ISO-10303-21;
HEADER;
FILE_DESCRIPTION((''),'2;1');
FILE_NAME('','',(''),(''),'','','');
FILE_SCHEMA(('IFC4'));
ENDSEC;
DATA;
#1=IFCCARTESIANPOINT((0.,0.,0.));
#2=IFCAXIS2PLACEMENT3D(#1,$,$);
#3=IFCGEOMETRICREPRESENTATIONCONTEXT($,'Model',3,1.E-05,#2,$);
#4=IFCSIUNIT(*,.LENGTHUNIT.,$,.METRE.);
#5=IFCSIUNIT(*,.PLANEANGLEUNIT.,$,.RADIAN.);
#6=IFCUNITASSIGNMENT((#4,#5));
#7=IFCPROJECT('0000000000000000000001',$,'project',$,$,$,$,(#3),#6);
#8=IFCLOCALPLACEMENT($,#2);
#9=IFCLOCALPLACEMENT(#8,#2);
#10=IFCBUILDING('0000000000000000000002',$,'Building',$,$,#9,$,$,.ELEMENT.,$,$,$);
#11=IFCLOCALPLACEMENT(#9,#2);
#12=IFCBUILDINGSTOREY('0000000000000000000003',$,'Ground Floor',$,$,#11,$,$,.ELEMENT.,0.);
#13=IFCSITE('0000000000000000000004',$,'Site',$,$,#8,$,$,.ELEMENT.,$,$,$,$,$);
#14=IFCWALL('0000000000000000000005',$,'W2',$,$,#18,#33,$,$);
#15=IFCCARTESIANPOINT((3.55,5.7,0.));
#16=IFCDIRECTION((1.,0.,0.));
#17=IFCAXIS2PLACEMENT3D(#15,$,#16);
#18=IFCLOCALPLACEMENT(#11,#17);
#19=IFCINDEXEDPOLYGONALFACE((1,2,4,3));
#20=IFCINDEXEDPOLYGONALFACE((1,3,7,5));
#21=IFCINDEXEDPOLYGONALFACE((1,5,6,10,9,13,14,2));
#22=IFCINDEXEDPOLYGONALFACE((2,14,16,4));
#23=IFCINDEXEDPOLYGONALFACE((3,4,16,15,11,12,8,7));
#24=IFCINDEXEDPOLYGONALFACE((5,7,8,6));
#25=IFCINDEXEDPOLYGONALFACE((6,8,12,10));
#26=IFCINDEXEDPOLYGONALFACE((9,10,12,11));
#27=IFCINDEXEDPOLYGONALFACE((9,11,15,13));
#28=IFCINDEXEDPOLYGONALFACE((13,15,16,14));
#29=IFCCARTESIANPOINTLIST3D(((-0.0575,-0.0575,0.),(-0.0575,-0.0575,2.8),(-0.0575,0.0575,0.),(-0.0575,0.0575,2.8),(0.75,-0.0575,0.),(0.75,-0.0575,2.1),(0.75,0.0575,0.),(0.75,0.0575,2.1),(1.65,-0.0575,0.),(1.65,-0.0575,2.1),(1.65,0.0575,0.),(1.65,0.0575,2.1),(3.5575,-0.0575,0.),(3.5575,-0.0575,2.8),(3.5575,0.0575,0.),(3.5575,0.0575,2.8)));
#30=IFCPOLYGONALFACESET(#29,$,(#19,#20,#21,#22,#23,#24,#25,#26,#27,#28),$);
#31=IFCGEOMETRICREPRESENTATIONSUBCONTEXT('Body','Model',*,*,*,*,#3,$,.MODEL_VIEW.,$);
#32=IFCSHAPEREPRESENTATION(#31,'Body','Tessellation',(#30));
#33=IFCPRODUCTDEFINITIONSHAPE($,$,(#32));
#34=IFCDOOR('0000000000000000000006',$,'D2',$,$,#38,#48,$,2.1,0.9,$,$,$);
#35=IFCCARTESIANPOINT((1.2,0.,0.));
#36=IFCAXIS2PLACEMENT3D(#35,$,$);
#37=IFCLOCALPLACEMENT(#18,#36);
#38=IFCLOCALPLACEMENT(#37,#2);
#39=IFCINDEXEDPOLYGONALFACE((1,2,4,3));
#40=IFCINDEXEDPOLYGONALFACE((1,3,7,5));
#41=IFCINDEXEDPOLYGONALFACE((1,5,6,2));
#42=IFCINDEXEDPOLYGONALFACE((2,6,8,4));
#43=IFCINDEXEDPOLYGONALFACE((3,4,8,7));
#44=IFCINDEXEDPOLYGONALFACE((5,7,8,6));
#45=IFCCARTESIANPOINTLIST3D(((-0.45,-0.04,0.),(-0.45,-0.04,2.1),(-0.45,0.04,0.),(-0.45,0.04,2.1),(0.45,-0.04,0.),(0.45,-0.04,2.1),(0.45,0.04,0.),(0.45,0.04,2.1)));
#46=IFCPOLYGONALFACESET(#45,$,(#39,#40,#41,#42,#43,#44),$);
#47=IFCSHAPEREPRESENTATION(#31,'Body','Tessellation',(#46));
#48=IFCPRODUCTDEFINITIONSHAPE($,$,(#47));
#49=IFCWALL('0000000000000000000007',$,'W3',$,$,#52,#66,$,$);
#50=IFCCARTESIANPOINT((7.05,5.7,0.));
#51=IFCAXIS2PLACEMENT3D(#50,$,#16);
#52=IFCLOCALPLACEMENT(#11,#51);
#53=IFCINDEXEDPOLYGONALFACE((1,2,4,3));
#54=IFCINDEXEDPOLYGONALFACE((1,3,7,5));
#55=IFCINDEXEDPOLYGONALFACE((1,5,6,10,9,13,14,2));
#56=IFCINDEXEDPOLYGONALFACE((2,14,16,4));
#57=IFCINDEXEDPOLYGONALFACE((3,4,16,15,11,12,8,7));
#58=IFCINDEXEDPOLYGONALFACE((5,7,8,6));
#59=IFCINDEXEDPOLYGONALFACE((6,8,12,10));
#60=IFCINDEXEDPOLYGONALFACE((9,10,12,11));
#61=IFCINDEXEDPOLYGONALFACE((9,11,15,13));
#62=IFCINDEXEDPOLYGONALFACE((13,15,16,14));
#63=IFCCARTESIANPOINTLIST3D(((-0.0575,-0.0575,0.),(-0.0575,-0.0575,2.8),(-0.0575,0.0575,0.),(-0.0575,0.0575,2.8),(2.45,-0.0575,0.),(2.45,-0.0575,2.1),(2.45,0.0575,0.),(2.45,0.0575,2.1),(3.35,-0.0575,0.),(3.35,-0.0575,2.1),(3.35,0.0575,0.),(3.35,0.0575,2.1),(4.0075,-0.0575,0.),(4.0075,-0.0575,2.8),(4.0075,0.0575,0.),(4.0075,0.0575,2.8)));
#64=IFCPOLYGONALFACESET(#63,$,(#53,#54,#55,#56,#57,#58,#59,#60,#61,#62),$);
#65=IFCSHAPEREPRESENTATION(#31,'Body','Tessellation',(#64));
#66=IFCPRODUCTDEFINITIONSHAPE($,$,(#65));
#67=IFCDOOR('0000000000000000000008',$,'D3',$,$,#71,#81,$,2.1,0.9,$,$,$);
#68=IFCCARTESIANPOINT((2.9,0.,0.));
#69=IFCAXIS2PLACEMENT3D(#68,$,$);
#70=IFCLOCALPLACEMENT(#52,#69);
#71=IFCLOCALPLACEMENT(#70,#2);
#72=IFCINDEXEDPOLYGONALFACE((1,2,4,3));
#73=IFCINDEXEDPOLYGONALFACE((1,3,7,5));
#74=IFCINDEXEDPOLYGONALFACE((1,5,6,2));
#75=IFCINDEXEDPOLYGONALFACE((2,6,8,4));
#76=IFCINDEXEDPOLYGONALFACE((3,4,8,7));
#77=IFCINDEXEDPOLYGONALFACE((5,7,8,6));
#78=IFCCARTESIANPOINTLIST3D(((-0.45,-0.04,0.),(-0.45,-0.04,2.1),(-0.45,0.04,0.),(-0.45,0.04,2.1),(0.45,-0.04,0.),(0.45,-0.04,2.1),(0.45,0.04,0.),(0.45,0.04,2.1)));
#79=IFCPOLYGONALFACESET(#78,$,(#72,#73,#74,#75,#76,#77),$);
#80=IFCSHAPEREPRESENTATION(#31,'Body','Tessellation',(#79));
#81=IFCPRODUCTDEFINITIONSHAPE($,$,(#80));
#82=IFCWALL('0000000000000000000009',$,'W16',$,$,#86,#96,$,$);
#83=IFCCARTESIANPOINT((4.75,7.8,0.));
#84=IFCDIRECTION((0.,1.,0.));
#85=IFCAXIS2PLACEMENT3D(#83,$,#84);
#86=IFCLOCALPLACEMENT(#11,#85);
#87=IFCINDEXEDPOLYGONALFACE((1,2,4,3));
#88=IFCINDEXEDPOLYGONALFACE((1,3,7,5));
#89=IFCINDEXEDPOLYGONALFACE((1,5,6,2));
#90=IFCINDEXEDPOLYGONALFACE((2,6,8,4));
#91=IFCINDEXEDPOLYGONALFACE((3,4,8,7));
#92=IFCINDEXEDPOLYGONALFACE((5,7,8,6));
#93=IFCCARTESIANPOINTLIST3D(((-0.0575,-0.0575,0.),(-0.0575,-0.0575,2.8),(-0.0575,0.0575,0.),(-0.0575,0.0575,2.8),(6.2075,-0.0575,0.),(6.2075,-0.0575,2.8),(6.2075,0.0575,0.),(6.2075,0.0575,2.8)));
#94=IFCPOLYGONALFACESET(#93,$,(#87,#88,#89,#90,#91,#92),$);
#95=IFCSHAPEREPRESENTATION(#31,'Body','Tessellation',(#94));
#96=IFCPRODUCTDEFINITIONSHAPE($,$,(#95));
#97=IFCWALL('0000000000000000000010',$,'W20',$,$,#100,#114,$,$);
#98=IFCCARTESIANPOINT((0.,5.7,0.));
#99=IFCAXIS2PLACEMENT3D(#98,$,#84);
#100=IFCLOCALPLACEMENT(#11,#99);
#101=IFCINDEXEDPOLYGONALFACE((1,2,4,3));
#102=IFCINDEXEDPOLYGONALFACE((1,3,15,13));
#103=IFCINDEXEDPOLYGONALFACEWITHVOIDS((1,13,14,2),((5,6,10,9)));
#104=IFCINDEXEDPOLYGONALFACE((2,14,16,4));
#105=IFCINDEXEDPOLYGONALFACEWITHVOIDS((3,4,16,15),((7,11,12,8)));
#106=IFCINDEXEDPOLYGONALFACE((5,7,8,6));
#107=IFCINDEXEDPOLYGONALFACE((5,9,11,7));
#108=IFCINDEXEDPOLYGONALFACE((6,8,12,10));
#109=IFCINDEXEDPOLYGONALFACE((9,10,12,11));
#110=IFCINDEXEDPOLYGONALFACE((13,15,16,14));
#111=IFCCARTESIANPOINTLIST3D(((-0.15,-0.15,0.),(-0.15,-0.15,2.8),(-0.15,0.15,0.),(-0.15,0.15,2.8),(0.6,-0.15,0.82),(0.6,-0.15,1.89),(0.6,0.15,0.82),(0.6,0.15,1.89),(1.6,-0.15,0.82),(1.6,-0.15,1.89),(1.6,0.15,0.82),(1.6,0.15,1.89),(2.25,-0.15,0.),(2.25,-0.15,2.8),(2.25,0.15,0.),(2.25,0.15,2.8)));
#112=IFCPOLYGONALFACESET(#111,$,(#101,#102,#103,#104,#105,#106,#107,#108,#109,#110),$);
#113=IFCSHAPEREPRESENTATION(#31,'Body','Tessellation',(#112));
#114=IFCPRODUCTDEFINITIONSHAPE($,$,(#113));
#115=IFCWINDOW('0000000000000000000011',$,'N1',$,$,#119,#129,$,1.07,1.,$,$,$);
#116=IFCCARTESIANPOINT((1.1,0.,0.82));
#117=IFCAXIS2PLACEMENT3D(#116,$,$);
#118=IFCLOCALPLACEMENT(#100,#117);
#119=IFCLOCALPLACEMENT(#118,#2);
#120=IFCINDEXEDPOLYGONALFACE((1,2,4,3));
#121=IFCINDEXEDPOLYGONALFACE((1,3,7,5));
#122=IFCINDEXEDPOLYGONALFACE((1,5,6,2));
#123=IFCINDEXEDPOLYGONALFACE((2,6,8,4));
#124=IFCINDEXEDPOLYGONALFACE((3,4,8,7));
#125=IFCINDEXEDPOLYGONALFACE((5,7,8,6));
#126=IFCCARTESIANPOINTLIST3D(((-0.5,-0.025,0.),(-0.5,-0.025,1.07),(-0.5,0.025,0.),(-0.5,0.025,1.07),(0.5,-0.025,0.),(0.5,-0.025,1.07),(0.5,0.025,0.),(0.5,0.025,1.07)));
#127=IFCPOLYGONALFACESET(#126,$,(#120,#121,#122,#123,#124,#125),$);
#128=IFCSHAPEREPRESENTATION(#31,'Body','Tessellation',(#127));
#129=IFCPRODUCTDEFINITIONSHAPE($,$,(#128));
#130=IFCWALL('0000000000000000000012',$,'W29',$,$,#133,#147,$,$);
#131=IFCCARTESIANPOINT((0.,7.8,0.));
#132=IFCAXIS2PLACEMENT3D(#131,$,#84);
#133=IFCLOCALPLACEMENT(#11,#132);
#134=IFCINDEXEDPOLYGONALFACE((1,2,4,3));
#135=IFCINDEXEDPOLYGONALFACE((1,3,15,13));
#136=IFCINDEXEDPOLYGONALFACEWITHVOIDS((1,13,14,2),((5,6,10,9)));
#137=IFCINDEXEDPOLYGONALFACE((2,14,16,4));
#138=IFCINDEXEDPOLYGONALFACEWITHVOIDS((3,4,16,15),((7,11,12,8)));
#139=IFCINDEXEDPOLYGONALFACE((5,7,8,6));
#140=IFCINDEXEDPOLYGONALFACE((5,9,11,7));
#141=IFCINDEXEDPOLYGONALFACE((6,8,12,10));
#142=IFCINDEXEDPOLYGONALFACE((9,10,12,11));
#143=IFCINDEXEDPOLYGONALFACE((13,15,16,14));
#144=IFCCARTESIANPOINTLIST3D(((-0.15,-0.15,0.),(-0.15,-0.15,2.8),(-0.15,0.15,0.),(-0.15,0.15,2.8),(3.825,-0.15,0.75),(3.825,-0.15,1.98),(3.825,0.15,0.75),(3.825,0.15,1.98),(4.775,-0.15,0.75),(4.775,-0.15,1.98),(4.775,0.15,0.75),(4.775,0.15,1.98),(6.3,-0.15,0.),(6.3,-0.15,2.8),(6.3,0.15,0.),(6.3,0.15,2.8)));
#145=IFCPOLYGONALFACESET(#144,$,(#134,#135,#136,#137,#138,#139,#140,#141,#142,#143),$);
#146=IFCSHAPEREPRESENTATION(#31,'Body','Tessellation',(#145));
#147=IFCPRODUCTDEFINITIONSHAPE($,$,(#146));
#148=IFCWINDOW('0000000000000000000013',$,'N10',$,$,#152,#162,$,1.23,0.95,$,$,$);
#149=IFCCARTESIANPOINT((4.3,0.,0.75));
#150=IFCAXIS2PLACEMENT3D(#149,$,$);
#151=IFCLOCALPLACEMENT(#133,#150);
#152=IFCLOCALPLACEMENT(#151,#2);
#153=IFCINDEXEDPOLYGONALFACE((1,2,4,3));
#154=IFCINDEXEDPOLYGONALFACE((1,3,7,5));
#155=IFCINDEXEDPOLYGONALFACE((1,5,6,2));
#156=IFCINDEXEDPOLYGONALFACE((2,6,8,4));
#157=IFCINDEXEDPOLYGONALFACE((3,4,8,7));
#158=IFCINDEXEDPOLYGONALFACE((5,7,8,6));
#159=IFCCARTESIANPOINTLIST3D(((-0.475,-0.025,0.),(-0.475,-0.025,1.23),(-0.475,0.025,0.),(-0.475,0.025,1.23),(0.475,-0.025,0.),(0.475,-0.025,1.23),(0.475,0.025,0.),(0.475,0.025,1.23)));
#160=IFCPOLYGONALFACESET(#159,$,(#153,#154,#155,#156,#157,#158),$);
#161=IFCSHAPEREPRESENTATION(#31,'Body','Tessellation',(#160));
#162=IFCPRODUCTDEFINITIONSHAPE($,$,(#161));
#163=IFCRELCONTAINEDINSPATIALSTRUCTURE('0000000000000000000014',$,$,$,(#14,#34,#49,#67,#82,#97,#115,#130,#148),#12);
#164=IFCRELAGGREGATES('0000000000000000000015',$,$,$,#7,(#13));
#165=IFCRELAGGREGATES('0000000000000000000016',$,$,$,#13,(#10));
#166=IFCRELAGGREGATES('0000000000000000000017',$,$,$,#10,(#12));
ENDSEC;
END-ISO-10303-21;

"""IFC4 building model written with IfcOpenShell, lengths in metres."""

from ifc_helpers import new_model, si_unit, frame, frame_2d, origin, origin_2d, place, context, subcontext, project, spatial, rectangle, extrude, element, fill, save


model = new_model("IFC4")

# Units and contexts
model_context = context("Model", 3, precision=1e-05, world=origin())
body_context = subcontext(model_context, "Body", "Model", "MODEL_VIEW")
ifc_project = project(units=[si_unit("LENGTHUNIT", "METRE"), si_unit("PLANEANGLEUNIT", "RADIAN")], contexts=[model_context])

# Site, building, storey
site_placement = place(None, origin())
site = spatial("IfcSite", under=ifc_project, at=site_placement, Name="Site", CompositionType="ELEMENT")
building_placement = place(site_placement, origin())
building = spatial("IfcBuilding", under=site, at=building_placement, Name="Building", CompositionType="ELEMENT")
storey_placement = place(building_placement, origin())
storey = spatial("IfcBuildingStorey", under=building, at=storey_placement, Name="Ground Floor", CompositionType="ELEMENT", Elevation=0.0)

# Walls, openings, doors
wall_1_placement = place(storey_placement, frame((3.55, 5.7, 0.0), x_axis=(1.0, 0.0, 0.0)))
wall_1 = element("IfcWall", 1, at=wall_1_placement, inside=storey, Name="W2", context=body_context, shape_type="SweptSolid", body=[
    extrude(rectangle(XDim=3.615, YDim=0.115, at=frame_2d((1.75, 0.0))), origin(), (0.0, 0.0, 1.0), 2.8),
])
opening_1_placement = place(wall_1_placement, frame((1.2, 0.0, 0.0)))
opening_1 = element("IfcOpeningElement", 2, at=opening_1_placement, cuts=wall_1, context=body_context, shape_type="SweptSolid", body=[
    extrude(rectangle(XDim=0.9, YDim=0.215, at=origin_2d()), origin(), (0.0, 0.0, 1.0), 2.1),
])
door_1_placement = place(opening_1_placement, origin())
door_1 = element("IfcDoor", 3, at=door_1_placement, inside=storey, Name="D2", OverallHeight=2.1, OverallWidth=0.9, context=body_context, shape_type="SweptSolid", body=[
    extrude(rectangle(XDim=0.9, YDim=0.08, at=origin_2d()), origin(), (0.0, 0.0, 1.0), 2.1),
])
fill(opening_1, door_1)
wall_2_placement = place(storey_placement, frame((7.05, 5.7, 0.0), x_axis=(1.0, 0.0, 0.0)))
wall_2 = element("IfcWall", 4, at=wall_2_placement, inside=storey, Name="W3", context=body_context, shape_type="SweptSolid", body=[
    extrude(rectangle(XDim=4.065, YDim=0.115, at=frame_2d((1.975, 0.0))), origin(), (0.0, 0.0, 1.0), 2.8),
])
opening_2_placement = place(wall_2_placement, frame((2.9, 0.0, 0.0)))
opening_2 = element("IfcOpeningElement", 5, at=opening_2_placement, cuts=wall_2, context=body_context, shape_type="SweptSolid", body=[
    extrude(rectangle(XDim=0.9, YDim=0.215, at=origin_2d()), origin(), (0.0, 0.0, 1.0), 2.1),
])
door_2_placement = place(opening_2_placement, origin())
door_2 = element("IfcDoor", 6, at=door_2_placement, inside=storey, Name="D3", OverallHeight=2.1, OverallWidth=0.9, context=body_context, shape_type="SweptSolid", body=[
    extrude(rectangle(XDim=0.9, YDim=0.08, at=origin_2d()), origin(), (0.0, 0.0, 1.0), 2.1),
])
fill(opening_2, door_2)

# Wall
wall_3_placement = place(storey_placement, frame((4.75, 7.8, 0.0), x_axis=(0.0, 1.0, 0.0)))
element("IfcWall", 7, at=wall_3_placement, inside=storey, Name="W16", context=body_context, shape_type="SweptSolid", body=[
    extrude(rectangle(XDim=6.265, YDim=0.115, at=frame_2d((3.075, 0.0))), origin(), (0.0, 0.0, 1.0), 2.8),
])

# Walls, openings, windows
wall_4_placement = place(storey_placement, frame((0.0, 5.7, 0.0), x_axis=(0.0, 1.0, 0.0)))
wall_4 = element("IfcWall", 8, at=wall_4_placement, inside=storey, Name="W20", context=body_context, shape_type="SweptSolid", body=[
    extrude(rectangle(XDim=2.4, YDim=0.3, at=frame_2d((1.05, 0.0))), origin(), (0.0, 0.0, 1.0), 2.8),
])
opening_3_placement = place(wall_4_placement, frame((1.1, 0.0, 0.82)))
opening_3 = element("IfcOpeningElement", 9, at=opening_3_placement, cuts=wall_4, context=body_context, shape_type="SweptSolid", body=[
    extrude(rectangle(XDim=1.0, YDim=0.4, at=origin_2d()), origin(), (0.0, 0.0, 1.0), 1.07),
])
window_1_placement = place(opening_3_placement, origin())
window_1 = element("IfcWindow", 10, at=window_1_placement, inside=storey, Name="N1", OverallHeight=1.07, OverallWidth=1.0, context=body_context, shape_type="SweptSolid", body=[
    extrude(rectangle(XDim=1.0, YDim=0.05, at=origin_2d()), origin(), (0.0, 0.0, 1.0), 1.07),
])
fill(opening_3, window_1)
wall_5_placement = place(storey_placement, frame((0.0, 7.8, 0.0), x_axis=(0.0, 1.0, 0.0)))
wall_5 = element("IfcWall", 11, at=wall_5_placement, inside=storey, Name="W29", context=body_context, shape_type="SweptSolid", body=[
    extrude(rectangle(XDim=6.45, YDim=0.3, at=frame_2d((3.075, 0.0))), origin(), (0.0, 0.0, 1.0), 2.8),
])
opening_4_placement = place(wall_5_placement, frame((4.3, 0.0, 0.75)))
opening_4 = element("IfcOpeningElement", 12, at=opening_4_placement, cuts=wall_5, context=body_context, shape_type="SweptSolid", body=[
    extrude(rectangle(XDim=0.95, YDim=0.4, at=origin_2d()), origin(), (0.0, 0.0, 1.0), 1.23),
])
window_2_placement = place(opening_4_placement, origin())
window_2 = element("IfcWindow", 13, at=window_2_placement, inside=storey, Name="N10", OverallHeight=1.23, OverallWidth=0.95, context=body_context, shape_type="SweptSolid", body=[
    extrude(rectangle(XDim=0.95, YDim=0.05, at=origin_2d()), origin(), (0.0, 0.0, 1.0), 1.23),
])
fill(opening_4, window_2)

save(model, "model.ifc")
